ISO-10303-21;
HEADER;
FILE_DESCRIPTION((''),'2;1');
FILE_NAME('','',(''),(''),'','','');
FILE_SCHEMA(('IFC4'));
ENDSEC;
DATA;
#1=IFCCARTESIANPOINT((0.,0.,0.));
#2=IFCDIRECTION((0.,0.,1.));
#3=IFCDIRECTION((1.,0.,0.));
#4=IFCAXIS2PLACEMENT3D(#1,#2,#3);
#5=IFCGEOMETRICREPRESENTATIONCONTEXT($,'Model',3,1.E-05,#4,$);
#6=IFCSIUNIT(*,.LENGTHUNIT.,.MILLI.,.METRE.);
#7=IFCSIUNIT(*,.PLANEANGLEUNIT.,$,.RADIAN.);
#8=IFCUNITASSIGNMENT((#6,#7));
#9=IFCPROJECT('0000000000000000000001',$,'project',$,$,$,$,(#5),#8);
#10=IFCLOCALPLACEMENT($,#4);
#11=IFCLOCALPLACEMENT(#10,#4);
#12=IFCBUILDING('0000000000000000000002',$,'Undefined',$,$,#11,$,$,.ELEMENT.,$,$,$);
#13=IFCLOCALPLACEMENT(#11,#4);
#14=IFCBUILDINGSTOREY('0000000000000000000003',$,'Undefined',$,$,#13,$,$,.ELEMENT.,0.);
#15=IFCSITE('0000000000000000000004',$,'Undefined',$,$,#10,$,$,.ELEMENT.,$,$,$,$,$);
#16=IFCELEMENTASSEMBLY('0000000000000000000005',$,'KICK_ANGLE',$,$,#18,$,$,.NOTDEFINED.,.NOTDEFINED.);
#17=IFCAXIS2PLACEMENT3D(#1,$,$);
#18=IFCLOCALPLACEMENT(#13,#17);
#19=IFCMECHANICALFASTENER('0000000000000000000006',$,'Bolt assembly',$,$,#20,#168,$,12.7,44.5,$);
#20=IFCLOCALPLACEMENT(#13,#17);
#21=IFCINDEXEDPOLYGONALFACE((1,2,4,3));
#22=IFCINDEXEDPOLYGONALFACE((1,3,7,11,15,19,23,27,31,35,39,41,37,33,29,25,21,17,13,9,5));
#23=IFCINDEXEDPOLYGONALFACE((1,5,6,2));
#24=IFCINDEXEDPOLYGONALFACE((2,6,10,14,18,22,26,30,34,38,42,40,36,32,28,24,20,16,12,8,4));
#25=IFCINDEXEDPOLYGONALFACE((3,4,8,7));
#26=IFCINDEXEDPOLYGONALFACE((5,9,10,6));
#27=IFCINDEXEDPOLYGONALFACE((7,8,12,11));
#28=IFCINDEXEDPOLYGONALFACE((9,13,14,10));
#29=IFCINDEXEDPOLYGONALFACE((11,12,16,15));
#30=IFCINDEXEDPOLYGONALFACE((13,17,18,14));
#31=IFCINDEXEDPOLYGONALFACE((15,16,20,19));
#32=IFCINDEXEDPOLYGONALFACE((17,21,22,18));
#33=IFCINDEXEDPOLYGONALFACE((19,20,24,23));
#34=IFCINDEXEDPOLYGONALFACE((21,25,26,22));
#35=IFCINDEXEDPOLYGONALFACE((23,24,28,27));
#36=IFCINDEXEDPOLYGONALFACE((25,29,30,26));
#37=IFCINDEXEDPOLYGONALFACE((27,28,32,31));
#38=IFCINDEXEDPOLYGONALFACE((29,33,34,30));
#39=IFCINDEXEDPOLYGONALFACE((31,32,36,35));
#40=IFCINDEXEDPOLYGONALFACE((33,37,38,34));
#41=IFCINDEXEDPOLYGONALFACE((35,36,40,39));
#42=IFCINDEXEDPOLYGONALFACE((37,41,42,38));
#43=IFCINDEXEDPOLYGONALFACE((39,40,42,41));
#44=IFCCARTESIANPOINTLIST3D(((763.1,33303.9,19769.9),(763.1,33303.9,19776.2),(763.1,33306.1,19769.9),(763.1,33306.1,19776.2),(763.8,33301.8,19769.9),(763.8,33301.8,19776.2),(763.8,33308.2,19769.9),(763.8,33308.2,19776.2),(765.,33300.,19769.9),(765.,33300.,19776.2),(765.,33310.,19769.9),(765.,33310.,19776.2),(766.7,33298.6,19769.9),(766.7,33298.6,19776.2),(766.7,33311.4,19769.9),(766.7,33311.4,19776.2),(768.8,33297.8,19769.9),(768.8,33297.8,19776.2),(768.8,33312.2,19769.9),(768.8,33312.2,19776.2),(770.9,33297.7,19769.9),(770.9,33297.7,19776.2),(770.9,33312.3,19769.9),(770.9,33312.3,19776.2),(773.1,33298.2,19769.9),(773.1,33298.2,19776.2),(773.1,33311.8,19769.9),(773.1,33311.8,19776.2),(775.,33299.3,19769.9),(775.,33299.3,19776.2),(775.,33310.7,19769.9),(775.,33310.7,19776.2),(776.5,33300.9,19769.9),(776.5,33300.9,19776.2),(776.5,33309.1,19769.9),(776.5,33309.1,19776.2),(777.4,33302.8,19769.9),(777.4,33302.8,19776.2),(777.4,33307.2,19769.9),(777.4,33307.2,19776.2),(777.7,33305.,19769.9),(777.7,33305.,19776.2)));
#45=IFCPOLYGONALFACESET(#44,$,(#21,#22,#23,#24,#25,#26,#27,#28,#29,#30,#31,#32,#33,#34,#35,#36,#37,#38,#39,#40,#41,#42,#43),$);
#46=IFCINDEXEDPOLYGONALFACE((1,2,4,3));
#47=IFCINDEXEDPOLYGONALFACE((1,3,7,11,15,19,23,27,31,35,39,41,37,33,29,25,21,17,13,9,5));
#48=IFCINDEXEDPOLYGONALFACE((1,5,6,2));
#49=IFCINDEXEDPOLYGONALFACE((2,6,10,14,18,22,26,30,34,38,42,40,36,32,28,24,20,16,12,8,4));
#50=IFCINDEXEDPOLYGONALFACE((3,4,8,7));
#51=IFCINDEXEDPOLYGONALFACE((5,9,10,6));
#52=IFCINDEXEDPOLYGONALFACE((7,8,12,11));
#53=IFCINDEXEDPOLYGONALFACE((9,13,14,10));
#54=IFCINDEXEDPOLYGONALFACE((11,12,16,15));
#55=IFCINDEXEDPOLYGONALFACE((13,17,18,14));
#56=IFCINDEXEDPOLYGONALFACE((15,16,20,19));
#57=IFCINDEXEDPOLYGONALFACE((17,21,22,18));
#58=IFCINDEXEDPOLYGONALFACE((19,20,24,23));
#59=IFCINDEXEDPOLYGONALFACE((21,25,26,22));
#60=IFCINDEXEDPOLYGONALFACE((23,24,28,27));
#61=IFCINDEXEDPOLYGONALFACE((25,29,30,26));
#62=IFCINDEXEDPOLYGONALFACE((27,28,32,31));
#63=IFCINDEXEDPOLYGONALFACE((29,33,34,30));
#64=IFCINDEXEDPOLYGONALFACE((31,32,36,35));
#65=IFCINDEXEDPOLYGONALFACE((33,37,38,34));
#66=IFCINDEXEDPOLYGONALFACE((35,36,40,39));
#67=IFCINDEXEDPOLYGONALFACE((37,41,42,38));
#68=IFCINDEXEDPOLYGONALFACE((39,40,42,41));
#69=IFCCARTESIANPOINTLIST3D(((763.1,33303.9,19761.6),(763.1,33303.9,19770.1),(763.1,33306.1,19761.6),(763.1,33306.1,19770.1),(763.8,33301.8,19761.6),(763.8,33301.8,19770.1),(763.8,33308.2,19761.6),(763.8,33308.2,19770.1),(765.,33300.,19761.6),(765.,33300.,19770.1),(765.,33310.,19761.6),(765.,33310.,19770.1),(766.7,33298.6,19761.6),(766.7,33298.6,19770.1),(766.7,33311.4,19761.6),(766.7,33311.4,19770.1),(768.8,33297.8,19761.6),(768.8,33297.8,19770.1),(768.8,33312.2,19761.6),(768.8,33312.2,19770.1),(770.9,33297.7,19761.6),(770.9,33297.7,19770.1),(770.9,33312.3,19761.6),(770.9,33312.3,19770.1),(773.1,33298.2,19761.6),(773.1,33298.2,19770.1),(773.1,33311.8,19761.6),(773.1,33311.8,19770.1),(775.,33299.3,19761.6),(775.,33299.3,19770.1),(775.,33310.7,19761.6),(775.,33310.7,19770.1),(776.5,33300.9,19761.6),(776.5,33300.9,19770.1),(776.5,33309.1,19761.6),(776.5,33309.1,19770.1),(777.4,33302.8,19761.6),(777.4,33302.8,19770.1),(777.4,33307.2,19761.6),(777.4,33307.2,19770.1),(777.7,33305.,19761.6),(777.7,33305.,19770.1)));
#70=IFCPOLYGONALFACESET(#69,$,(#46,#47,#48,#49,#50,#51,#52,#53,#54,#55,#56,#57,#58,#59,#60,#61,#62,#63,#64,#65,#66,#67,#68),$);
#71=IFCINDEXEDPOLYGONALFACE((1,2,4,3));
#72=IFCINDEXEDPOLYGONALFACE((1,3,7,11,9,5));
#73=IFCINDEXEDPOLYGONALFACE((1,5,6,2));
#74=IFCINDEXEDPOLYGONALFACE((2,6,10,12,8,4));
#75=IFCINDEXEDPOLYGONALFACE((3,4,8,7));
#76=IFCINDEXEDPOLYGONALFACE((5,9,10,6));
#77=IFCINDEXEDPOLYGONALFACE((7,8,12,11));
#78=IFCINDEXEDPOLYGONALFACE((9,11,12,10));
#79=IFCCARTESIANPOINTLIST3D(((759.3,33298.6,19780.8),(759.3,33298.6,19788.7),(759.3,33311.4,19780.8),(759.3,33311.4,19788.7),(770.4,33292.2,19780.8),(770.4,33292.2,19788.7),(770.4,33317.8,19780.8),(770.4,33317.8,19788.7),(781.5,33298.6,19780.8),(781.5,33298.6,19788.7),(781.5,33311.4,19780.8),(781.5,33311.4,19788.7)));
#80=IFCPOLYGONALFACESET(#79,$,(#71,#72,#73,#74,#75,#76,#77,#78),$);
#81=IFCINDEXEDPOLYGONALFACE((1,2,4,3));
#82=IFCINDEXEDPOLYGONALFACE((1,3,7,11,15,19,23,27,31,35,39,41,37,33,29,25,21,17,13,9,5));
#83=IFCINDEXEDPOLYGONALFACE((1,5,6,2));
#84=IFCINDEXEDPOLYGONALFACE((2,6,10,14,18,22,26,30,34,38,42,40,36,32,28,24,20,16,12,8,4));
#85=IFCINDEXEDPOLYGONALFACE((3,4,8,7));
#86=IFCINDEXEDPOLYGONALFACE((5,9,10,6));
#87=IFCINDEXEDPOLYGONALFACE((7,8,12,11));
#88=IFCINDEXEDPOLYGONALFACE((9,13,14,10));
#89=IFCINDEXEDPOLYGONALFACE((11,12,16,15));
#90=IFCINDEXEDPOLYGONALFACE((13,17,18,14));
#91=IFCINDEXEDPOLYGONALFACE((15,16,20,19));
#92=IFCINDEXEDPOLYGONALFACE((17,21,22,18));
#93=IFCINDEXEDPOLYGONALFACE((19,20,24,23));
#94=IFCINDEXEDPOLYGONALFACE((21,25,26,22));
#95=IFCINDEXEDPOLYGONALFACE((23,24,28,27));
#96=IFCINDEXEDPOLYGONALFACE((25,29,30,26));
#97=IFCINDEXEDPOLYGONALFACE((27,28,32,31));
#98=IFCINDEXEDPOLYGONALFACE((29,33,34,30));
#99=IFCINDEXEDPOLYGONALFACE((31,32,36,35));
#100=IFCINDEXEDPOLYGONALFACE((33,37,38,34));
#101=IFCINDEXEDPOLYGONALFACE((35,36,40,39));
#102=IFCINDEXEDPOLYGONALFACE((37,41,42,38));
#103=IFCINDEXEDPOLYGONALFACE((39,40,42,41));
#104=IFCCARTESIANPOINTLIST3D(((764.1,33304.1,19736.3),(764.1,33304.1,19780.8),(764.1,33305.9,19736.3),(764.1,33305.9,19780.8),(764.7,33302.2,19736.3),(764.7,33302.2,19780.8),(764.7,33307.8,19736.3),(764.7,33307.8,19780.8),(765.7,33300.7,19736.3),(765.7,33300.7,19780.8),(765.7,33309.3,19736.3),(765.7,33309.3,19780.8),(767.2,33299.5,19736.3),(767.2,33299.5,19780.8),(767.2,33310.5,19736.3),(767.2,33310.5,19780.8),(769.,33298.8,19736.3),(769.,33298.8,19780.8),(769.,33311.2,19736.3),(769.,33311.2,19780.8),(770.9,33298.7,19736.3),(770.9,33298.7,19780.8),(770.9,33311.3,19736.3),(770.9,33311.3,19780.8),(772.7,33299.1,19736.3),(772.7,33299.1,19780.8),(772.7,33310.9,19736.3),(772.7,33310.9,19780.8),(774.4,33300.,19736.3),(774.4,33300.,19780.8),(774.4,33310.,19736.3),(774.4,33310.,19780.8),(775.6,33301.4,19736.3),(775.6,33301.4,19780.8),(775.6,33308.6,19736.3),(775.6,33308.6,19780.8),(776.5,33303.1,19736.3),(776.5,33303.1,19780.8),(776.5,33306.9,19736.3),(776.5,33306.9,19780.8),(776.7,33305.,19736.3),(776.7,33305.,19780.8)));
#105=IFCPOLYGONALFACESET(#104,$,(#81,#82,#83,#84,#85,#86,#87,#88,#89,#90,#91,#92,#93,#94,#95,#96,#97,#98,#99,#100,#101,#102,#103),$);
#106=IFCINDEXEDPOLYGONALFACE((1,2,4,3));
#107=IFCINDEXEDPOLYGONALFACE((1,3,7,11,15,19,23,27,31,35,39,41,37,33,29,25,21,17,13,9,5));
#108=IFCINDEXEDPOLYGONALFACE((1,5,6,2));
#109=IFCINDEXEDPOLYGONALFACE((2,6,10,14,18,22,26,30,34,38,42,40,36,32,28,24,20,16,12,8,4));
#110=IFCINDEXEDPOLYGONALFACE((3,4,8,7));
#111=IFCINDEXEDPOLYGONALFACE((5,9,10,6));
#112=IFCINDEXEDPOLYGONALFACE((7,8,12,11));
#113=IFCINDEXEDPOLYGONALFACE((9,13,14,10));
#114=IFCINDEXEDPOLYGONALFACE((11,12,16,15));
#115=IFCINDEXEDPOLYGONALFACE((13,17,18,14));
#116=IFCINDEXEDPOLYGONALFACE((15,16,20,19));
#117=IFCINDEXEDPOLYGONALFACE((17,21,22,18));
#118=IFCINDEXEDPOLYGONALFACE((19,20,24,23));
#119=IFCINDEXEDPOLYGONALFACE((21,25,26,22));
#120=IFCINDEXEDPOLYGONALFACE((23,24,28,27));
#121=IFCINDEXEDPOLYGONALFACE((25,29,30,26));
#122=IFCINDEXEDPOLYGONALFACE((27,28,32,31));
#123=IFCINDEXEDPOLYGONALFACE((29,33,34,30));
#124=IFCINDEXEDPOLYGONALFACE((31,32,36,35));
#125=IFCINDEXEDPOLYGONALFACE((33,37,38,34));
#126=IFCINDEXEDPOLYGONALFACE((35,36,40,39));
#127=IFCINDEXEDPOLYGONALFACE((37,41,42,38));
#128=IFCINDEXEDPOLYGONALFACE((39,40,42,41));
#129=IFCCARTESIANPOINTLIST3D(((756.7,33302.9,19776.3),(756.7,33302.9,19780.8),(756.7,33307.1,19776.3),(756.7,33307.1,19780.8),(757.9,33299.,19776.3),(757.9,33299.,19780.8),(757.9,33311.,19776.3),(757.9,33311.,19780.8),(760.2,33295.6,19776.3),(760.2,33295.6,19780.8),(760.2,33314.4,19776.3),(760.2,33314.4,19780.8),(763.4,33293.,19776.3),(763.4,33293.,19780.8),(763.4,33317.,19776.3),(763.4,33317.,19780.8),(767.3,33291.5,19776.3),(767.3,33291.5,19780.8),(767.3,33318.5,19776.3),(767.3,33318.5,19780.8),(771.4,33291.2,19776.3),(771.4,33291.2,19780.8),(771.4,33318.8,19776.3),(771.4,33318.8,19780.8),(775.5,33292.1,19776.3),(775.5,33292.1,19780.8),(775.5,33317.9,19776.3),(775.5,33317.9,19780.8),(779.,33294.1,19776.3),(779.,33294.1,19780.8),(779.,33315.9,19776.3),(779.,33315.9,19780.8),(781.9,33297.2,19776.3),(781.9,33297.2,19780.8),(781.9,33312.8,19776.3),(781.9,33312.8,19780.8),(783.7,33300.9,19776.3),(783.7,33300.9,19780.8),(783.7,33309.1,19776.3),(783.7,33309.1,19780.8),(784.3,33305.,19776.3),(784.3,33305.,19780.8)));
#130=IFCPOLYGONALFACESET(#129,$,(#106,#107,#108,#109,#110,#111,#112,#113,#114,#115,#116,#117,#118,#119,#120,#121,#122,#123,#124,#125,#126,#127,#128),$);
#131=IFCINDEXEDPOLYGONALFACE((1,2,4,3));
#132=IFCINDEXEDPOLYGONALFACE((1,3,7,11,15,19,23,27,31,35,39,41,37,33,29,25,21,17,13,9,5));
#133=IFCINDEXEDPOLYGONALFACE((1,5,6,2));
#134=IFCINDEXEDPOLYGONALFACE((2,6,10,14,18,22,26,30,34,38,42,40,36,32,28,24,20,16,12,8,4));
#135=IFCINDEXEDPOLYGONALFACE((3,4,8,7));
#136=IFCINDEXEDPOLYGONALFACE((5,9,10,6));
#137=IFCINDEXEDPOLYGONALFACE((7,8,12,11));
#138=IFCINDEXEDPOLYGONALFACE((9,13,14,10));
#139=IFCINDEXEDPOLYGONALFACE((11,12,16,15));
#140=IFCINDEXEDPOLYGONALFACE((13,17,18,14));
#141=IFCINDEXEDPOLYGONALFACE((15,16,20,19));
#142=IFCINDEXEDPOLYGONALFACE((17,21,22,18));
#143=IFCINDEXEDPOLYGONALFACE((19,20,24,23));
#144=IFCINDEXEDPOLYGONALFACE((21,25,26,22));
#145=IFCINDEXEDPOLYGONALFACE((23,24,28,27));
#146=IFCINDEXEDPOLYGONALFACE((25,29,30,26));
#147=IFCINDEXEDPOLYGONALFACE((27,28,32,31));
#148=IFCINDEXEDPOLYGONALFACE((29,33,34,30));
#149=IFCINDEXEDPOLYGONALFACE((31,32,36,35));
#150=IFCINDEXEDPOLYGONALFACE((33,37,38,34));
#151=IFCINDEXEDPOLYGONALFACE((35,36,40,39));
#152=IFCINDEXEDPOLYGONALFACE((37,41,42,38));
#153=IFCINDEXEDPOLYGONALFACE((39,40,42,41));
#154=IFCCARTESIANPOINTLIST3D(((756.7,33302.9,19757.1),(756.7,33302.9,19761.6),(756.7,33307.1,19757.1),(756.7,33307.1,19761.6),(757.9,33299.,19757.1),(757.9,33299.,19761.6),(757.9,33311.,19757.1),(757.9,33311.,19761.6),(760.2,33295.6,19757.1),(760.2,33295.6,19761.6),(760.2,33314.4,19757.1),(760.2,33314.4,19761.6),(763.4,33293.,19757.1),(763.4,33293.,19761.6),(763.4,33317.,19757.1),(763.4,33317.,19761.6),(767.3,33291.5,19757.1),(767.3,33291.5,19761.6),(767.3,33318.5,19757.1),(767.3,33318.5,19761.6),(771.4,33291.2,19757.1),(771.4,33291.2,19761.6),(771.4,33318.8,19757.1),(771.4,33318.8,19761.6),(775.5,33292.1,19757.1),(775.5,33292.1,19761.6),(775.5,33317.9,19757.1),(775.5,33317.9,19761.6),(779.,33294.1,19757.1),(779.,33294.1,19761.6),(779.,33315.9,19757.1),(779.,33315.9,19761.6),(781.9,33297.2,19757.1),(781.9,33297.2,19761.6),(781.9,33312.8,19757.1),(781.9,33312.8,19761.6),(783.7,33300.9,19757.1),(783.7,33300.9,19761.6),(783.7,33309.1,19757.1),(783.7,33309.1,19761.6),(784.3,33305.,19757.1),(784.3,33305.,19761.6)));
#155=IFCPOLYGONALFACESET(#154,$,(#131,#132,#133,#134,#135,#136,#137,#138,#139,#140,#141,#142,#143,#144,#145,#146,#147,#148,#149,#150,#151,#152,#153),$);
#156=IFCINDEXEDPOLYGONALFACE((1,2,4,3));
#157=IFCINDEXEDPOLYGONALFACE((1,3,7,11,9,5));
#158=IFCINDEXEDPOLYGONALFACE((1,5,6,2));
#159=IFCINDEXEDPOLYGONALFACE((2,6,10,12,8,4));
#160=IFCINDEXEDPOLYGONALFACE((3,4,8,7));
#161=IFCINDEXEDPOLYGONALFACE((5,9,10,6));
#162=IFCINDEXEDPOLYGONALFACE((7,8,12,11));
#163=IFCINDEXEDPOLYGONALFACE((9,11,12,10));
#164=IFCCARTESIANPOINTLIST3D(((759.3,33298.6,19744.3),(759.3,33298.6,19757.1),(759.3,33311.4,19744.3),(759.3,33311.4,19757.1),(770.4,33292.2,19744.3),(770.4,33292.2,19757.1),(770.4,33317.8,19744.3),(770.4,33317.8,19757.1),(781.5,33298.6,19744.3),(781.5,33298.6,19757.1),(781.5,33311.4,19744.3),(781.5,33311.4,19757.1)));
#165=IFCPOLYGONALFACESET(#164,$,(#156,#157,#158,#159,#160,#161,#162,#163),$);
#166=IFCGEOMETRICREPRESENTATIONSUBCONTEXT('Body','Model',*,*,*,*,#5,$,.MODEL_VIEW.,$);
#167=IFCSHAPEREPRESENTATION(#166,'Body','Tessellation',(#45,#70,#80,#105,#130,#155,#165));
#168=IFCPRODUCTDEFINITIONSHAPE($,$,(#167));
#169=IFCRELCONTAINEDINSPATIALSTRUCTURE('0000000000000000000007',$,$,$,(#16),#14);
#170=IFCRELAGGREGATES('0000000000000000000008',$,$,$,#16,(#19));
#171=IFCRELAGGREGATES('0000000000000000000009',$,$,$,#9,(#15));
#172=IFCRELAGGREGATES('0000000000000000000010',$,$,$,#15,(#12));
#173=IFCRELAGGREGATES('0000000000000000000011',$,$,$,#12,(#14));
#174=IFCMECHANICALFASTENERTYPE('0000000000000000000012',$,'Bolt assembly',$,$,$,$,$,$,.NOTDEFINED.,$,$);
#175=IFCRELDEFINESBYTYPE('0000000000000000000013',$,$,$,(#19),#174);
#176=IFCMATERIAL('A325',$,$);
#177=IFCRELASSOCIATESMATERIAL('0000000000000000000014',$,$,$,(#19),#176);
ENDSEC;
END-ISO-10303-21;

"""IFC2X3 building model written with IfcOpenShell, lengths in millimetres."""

from ifc_helpers import new_model, si_unit, frame, origin_with_axes, origin_2d_with_axis, place, context, subcontext, project, spatial, polyline, circle, outline, extrude, source, transform, mapped, material, type_object, element, aggregate, save


model = new_model("IFC2X3")

# Units and contexts
model_context = context("Model", 3, precision=1e-05, world=origin_with_axes())
body_context = subcontext(model_context, "Body", "Model", "MODEL_VIEW")
ifc_project = project(units=[si_unit("LENGTHUNIT", "METRE", prefix="MILLI"), si_unit("PLANEANGLEUNIT", "RADIAN")], contexts=[model_context])

# Site, building, storey
site_placement = place(None, origin_with_axes())
site = spatial("IfcSite", under=ifc_project, at=site_placement, Name="Undefined", CompositionType="ELEMENT")
building_placement = place(site_placement, origin_with_axes())
building = spatial("IfcBuilding", under=site, at=building_placement, Name="Undefined", CompositionType="ELEMENT")
storey_placement = place(building_placement, origin_with_axes())
storey = spatial("IfcBuildingStorey", under=building, at=storey_placement, Name="Undefined", CompositionType="ELEMENT", Elevation=0.0)

# Element assembly
assembly_1_placement = place(storey_placement, origin_with_axes())
assembly_1 = element("IfcElementAssembly", 1, at=assembly_1_placement, inside=storey, Name="KICK_ANGLE", AssemblyPlace="NOTDEFINED", PredefinedType="NOTDEFINED")

# Shared definitions
ifc_material_1 = material(Name="A325")
mechanical_fastener_type = type_object("IfcMechanicalFastenerType", Name="Bolt assembly")

# Mechanical fastener
shared_shape_1 = source(origin_with_axes(), body_context, "Body", "SweptSolid", [
    extrude(circle(Radius=7.3, at=origin_2d_with_axis()), frame((0.0, 0.1, 0.0), z_axis=(0.0, 1.0, 0.0), x_axis=(1.0, 0.0, 0.0)), (0.0, 0.0, 1.0), 6.3),
    extrude(circle(Radius=7.3, at=origin_2d_with_axis()), frame((0.0, 6.2, 0.0), z_axis=(0.0, 1.0, 0.0), x_axis=(1.0, 0.0, 0.0)), (0.0, 0.0, 1.0), 8.5),
    extrude(outline(polyline([(11.1, -6.4), (11.1, 6.4), (0.0, 12.8), (-11.1, 6.4), (-11.1, -6.4), (0.0, -12.8), (11.1, -6.4)])), frame((0.0, -12.4, 0.0), z_axis=(0.0, 1.0, 0.0), x_axis=(1.0, 0.0, 0.0)), (0.0, 0.0, 1.0), 7.9),
    extrude(circle(Radius=6.3, at=origin_2d_with_axis()), frame((0.0, -4.5, 0.0), z_axis=(0.0, 1.0, 0.0), x_axis=(1.0, 0.0, 0.0)), (0.0, 0.0, 1.0), 44.5),
    extrude(circle(Radius=13.9, at=origin_2d_with_axis()), frame((0.0, -4.5, 0.0), z_axis=(0.0, 1.0, 0.0), x_axis=(1.0, 0.0, 0.0)), (0.0, 0.0, 1.0), 4.5),
    extrude(circle(Radius=13.9, at=origin_2d_with_axis()), frame((0.0, 14.7, 0.0), z_axis=(0.0, 1.0, 0.0), x_axis=(1.0, 0.0, 0.0)), (0.0, 0.0, 1.0), 4.5),
    extrude(outline(polyline([(11.1, -6.4), (11.1, 6.4), (0.0, 12.8), (-11.1, 6.4), (-11.1, -6.4), (0.0, -12.8), (11.1, -6.4)])), frame((0.0, 19.2, 0.0), z_axis=(0.0, 1.0, 0.0), x_axis=(1.0, 0.0, 0.0)), (0.0, 0.0, 1.0), 12.8),
])
mechanical_fastener_1_placement = place(assembly_1_placement, frame((770.4, 33305.0, 19776.3), z_axis=(0.0, 1.0, 0.0), x_axis=(1.0, 0.0, 0.0)))
mechanical_fastener_1 = element("IfcMechanicalFastener", 2, at=mechanical_fastener_1_placement, type_object=mechanical_fastener_type, material=ifc_material_1, Name="Bolt assembly", NominalDiameter=12.7, NominalLength=44.5, context=body_context, shape_type="MappedRepresentation", body=[
    mapped(shared_shape_1, transform((0.0, 0.0, 0.0))),
])
aggregate(assembly_1, [mechanical_fastener_1])

save(model, "model.ifc")
